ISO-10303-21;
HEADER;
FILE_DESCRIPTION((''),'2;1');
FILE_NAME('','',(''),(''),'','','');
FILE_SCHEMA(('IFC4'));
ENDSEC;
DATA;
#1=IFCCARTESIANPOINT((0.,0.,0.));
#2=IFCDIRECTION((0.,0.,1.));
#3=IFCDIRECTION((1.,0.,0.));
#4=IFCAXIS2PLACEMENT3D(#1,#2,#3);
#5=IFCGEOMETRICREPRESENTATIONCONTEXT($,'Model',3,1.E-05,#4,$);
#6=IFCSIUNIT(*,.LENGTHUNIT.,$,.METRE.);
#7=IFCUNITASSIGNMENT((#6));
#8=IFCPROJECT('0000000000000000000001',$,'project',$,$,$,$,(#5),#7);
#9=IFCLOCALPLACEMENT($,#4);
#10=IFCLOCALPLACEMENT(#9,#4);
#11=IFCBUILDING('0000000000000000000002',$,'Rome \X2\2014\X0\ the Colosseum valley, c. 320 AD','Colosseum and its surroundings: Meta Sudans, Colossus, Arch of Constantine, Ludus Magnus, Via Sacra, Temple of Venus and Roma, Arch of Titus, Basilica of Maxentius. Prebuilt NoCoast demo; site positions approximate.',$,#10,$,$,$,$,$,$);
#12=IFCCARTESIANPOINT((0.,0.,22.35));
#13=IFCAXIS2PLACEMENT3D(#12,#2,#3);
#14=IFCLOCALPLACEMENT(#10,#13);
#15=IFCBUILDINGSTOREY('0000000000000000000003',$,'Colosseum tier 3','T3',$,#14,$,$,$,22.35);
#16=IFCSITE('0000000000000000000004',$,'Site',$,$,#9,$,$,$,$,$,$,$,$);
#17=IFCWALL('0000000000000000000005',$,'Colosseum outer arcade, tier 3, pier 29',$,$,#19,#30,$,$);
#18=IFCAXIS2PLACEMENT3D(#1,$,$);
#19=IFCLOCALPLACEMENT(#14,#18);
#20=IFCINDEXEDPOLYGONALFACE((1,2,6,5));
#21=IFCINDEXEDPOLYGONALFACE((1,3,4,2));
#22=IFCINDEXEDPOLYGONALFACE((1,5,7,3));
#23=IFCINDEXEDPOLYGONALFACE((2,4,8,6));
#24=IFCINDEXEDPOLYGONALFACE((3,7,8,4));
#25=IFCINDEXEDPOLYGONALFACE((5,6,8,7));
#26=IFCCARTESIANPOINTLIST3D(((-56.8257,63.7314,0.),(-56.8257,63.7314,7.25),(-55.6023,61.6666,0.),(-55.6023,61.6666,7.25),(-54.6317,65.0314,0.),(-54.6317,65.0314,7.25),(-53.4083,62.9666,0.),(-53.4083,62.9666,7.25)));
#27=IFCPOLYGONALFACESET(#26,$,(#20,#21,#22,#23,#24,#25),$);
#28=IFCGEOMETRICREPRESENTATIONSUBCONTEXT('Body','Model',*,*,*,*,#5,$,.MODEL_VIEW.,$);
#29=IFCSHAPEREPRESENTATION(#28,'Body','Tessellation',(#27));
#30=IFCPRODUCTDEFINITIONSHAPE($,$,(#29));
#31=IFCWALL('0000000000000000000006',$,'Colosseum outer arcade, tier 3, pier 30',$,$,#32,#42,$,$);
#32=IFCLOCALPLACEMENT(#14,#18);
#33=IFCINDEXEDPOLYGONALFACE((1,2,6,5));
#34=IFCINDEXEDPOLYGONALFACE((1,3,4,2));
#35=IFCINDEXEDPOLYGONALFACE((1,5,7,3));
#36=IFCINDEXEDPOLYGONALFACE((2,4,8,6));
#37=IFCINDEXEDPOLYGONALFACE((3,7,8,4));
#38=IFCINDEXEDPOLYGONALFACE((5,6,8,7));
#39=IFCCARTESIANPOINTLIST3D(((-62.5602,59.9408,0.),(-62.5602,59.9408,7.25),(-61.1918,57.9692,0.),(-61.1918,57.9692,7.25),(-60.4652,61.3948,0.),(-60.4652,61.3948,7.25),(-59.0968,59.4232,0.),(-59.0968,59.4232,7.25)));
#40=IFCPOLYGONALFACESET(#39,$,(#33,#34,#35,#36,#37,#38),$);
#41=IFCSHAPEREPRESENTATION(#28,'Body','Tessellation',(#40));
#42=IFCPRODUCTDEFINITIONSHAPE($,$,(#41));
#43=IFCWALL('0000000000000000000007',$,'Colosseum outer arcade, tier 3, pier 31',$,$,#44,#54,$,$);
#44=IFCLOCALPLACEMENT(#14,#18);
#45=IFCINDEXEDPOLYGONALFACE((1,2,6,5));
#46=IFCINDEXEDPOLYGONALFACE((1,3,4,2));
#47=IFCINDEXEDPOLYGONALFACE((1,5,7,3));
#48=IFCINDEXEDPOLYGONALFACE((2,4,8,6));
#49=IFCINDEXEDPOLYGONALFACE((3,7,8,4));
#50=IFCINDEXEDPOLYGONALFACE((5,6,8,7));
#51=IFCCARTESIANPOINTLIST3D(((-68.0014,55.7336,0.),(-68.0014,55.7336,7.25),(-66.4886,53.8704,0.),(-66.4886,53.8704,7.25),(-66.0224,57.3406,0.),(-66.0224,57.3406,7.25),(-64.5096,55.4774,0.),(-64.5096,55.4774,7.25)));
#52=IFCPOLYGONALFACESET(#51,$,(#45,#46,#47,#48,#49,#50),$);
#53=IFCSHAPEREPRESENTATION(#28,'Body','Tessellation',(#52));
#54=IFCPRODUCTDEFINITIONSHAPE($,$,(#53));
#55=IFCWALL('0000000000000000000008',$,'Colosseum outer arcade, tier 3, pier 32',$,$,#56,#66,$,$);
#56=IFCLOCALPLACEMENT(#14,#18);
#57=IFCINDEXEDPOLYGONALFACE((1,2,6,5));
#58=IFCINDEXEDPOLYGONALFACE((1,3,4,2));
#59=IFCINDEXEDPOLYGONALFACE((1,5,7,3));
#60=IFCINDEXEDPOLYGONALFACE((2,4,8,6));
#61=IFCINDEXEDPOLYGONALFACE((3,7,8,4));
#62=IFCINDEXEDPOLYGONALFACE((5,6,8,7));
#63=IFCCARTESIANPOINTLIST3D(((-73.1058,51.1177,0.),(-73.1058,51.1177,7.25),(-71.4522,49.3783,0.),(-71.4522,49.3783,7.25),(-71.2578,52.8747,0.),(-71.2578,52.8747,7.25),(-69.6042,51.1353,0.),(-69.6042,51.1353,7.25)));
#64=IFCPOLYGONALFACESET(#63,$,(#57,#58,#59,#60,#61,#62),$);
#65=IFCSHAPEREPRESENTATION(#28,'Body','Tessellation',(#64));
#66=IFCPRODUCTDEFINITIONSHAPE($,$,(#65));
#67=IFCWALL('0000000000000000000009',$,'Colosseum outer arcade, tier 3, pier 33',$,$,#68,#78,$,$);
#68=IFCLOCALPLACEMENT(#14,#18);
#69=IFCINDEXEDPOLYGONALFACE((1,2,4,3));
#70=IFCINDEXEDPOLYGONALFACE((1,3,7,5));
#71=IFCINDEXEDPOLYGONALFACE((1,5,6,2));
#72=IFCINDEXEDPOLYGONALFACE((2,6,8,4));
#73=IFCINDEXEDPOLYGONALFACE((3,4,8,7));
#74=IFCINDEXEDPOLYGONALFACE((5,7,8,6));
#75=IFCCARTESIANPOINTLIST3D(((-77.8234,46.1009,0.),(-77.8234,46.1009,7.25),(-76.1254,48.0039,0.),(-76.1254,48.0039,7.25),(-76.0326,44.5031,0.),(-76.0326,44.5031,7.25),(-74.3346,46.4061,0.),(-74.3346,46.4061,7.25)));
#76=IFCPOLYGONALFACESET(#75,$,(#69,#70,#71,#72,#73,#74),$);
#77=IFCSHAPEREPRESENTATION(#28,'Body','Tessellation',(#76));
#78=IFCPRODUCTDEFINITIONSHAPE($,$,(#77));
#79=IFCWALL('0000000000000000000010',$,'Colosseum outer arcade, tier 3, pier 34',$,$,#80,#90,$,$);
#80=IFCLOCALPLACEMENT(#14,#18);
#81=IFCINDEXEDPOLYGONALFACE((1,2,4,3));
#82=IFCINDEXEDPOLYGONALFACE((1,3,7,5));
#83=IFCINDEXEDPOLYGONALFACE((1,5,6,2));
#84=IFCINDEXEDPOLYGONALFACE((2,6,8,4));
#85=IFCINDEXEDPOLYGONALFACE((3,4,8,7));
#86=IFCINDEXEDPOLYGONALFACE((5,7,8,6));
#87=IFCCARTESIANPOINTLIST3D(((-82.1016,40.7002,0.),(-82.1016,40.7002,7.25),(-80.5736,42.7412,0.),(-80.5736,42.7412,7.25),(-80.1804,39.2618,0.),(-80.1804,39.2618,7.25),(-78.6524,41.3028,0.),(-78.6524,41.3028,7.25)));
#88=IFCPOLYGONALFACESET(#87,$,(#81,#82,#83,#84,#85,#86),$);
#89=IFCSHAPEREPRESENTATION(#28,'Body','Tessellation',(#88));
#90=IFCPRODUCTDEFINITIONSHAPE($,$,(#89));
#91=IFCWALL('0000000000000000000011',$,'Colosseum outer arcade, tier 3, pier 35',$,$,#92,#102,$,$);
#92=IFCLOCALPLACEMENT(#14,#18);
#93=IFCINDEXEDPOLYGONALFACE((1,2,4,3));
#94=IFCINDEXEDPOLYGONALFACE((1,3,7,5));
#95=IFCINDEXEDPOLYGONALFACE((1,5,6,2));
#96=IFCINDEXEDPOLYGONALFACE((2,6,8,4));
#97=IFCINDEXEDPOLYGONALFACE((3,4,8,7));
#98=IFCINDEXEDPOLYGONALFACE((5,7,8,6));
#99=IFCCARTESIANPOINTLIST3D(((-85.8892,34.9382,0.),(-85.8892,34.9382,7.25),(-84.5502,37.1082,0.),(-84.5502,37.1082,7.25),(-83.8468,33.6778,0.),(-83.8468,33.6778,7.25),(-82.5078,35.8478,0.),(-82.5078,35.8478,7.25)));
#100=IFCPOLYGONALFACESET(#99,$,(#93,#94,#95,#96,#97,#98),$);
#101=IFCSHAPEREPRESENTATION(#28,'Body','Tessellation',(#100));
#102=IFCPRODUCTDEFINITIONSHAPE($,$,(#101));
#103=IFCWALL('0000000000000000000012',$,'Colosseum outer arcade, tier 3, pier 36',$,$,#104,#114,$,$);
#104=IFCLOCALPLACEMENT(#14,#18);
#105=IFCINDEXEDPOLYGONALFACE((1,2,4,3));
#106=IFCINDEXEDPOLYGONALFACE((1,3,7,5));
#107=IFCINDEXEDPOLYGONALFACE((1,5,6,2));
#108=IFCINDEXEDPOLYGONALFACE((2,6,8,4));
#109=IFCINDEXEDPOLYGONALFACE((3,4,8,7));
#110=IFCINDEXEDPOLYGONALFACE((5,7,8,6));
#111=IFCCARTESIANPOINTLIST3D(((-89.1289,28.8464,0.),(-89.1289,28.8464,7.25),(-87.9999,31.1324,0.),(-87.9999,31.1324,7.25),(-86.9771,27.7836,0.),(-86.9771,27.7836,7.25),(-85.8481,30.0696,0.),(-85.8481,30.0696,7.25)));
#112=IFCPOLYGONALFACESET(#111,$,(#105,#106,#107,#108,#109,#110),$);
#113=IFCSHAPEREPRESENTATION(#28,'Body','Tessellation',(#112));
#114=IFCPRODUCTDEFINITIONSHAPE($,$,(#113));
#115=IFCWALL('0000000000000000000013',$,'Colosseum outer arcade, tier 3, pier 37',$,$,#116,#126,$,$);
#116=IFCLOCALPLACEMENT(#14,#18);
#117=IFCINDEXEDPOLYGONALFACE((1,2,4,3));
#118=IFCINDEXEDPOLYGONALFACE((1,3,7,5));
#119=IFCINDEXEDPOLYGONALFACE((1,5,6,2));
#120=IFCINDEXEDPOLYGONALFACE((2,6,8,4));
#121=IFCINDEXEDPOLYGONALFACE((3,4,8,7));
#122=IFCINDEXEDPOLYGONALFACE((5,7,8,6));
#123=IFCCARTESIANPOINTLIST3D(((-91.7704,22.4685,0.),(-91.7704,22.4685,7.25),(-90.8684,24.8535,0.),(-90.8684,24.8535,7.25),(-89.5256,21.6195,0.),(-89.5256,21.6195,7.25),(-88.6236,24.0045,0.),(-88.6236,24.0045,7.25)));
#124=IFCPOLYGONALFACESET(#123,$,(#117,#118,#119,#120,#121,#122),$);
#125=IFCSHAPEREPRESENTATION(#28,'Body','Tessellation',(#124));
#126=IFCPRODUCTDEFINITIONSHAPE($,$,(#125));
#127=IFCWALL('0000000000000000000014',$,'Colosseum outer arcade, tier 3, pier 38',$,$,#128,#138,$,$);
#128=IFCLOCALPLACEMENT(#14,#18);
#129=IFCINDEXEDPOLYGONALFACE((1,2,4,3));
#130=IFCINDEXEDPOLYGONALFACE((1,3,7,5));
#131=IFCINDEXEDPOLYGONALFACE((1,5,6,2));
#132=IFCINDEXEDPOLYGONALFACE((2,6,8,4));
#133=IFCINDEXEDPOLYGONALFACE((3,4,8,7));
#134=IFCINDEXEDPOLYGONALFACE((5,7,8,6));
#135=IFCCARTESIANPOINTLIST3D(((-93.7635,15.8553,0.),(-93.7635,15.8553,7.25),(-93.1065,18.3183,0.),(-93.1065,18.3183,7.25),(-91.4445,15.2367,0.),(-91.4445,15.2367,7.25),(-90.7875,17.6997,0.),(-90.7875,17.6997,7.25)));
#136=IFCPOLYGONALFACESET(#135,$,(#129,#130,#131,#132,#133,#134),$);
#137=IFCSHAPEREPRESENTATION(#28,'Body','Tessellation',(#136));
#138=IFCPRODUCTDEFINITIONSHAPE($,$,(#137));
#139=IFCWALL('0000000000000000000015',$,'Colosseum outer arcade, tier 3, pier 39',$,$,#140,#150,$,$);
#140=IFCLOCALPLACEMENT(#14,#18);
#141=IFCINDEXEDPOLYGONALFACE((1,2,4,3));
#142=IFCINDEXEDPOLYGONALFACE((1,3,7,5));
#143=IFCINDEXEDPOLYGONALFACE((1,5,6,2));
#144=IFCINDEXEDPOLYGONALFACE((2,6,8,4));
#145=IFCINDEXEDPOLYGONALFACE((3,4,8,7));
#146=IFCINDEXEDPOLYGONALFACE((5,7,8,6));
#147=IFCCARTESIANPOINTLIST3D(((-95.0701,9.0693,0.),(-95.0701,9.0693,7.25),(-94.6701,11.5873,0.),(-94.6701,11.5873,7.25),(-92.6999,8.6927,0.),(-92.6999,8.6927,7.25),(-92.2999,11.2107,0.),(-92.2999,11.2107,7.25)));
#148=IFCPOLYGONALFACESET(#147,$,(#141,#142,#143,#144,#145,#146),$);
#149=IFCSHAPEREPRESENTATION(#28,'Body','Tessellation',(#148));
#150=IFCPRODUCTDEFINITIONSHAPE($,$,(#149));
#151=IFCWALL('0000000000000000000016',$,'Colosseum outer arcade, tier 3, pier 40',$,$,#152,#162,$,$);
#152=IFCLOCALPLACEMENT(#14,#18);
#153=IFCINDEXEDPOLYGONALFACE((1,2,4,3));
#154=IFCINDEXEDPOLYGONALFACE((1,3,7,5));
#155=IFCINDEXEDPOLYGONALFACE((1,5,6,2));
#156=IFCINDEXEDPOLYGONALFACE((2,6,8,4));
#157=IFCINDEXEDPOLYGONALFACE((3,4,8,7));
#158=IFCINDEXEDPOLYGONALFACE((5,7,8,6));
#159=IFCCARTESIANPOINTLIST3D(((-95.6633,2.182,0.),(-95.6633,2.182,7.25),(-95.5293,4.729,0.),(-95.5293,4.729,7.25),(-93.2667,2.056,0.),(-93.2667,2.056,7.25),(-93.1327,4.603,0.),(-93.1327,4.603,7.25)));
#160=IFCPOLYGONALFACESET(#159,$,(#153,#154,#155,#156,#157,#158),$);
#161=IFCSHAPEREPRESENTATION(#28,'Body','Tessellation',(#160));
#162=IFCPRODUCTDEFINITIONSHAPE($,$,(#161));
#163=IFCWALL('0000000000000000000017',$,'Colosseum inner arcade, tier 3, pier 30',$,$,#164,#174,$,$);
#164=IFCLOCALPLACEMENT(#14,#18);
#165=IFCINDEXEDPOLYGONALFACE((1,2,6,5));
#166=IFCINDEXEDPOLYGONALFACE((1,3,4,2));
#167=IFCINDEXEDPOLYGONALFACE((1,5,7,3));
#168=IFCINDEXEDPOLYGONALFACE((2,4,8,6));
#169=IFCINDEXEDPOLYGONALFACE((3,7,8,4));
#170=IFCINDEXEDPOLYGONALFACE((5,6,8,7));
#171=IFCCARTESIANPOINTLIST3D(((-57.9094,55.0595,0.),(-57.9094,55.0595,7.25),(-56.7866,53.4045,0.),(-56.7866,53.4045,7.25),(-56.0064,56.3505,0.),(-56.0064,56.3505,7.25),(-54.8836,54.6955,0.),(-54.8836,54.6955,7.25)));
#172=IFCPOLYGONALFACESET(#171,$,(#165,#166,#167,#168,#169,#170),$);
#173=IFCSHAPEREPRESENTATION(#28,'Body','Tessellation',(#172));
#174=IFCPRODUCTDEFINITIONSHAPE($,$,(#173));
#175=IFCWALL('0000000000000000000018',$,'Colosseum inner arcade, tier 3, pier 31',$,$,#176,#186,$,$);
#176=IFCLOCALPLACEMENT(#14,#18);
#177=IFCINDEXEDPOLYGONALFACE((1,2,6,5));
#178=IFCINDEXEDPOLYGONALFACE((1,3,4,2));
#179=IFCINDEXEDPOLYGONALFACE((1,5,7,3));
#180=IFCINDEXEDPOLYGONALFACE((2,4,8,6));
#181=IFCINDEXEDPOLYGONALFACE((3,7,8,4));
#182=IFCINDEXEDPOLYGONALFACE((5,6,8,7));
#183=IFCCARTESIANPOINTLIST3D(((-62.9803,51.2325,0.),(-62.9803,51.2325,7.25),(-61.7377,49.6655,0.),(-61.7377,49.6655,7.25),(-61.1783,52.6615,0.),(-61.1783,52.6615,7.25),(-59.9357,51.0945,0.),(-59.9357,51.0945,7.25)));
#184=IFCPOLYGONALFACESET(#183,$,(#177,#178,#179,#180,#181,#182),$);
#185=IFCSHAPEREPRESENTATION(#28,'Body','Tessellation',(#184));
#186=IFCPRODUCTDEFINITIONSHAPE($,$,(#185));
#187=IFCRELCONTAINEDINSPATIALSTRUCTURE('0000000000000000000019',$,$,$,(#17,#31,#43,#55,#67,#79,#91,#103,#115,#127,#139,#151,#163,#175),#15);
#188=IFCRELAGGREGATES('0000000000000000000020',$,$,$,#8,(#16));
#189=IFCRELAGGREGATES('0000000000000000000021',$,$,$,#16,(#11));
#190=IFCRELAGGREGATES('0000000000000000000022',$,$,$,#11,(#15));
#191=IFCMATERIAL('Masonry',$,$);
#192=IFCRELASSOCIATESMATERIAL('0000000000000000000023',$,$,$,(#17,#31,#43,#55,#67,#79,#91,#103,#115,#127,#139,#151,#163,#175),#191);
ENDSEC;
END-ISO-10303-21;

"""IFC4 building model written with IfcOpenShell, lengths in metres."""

from ifc_helpers import new_model, si_unit, frame, origin_with_axes, place, context, subcontext, project, spatial, indexed_curve, outline, extrude, material, element, save


model = new_model("IFC4")

# Units and contexts
model_context = context("Model", 3, precision=1e-05, world=origin_with_axes())
body_context = subcontext(model_context, "Body", "Model", "MODEL_VIEW")
ifc_project = project(units=[si_unit("LENGTHUNIT", "METRE")], contexts=[model_context])

# Site, building, storey
site_placement = place(None, origin_with_axes())
site = spatial("IfcSite", under=ifc_project, at=site_placement, Name="Site")
building_placement = place(site_placement, origin_with_axes())
building = spatial("IfcBuilding", under=site, at=building_placement, Name="Rome — the Colosseum valley, c. 320 AD", Description="Colosseum and its surroundings: Meta Sudans, Colossus, Arch of Constantine, Ludus Magnus, Via Sacra, Temple of Venus and Roma, Arch of Titus, Basilica of Maxentius. Prebuilt NoCoast demo; site positions approximate.")
storey_placement = place(building_placement, frame((0.0, 0.0, 22.35), z_axis=(0.0, 0.0, 1.0), x_axis=(1.0, 0.0, 0.0)))
storey = spatial("IfcBuildingStorey", under=building, at=storey_placement, Name="Colosseum tier 3", Description="T3", Elevation=22.35)

# Walls
ifc_material = material(Name="Masonry")
wall_1_placement = place(storey_placement, frame((-54.02, 63.999, 0.0), z_axis=(0.0, 0.0, 1.0), x_axis=(-0.860317, -0.509759, 0.0)))
element("IfcWall", 1, at=wall_1_placement, inside=storey, material=ifc_material, Name="Colosseum outer arcade, tier 3, pier 29", context=body_context, shape_type="SweptSolid", body=[
    extrude(outline(indexed_curve([(0.0, 0.0), (0.0, 2.4), (2.5502, 2.4), (2.5502, 0.0), (0.0, 0.0)], self_intersect=False)), frame((0.0, -1.2, 0.0), z_axis=(0.0, 0.0, 1.0), x_axis=(1.0, 0.0, 0.0)), (0.0, 0.0, 1.0), 7.25),
])
wall_2_placement = place(storey_placement, frame((-59.781, 60.409, 0.0), z_axis=(0.0, 0.0, 1.0), x_axis=(-0.821528, -0.570168, 0.0)))
element("IfcWall", 2, at=wall_2_placement, inside=storey, material=ifc_material, Name="Colosseum outer arcade, tier 3, pier 30", context=body_context, shape_type="SweptSolid", body=[
    extrude(outline(indexed_curve([(0.0, 0.0), (0.0, 2.4), (2.5501, 2.4), (2.5501, 0.0), (0.0, 0.0)], self_intersect=False)), frame((0.0, -1.2, 0.0), z_axis=(0.0, 0.0, 1.0), x_axis=(1.0, 0.0, 0.0)), (0.0, 0.0, 1.0), 7.25),
])
wall_3_placement = place(storey_placement, frame((-65.266, 56.409, 0.0), z_axis=(0.0, 0.0, 1.0), x_axis=(-0.776294, -0.630371, 0.0)))
element("IfcWall", 3, at=wall_3_placement, inside=storey, material=ifc_material, Name="Colosseum outer arcade, tier 3, pier 31", context=body_context, shape_type="SweptSolid", body=[
    extrude(outline(indexed_curve([(0.0, 0.0), (0.0, 2.4), (2.5493, 2.4), (2.5493, 0.0), (0.0, 0.0)], self_intersect=False)), frame((0.0, -1.2, 0.0), z_axis=(0.0, 0.0, 1.0), x_axis=(1.0, 0.0, 0.0)), (0.0, 0.0, 1.0), 7.25),
])
wall_4_placement = place(storey_placement, frame((-70.431, 52.005, 0.0), z_axis=(0.0, 0.0, 1.0), x_axis=(-0.724725, -0.689038, 0.0)))
element("IfcWall", 4, at=wall_4_placement, inside=storey, material=ifc_material, Name="Colosseum outer arcade, tier 3, pier 32", context=body_context, shape_type="SweptSolid", body=[
    extrude(outline(indexed_curve([(0.0, 0.0), (0.0, 2.4), (2.5499, 2.4), (2.5499, 0.0), (0.0, 0.0)], self_intersect=False)), frame((0.0, -1.2, 0.0), z_axis=(0.0, 0.0, 1.0), x_axis=(1.0, 0.0, 0.0)), (0.0, 0.0, 1.0), 7.25),
])
wall_5_placement = place(storey_placement, frame((-75.23, 47.205, 0.0), z_axis=(0.0, 0.0, 1.0), x_axis=(-0.665774, -0.746153, 0.0)))
element("IfcWall", 5, at=wall_5_placement, inside=storey, material=ifc_material, Name="Colosseum outer arcade, tier 3, pier 33", context=body_context, shape_type="SweptSolid", body=[
    extrude(outline(indexed_curve([(0.0, 0.0), (0.0, 2.4), (2.5504, 2.4), (2.5504, 0.0), (0.0, 0.0)], self_intersect=False)), frame((0.0, -1.2, 0.0), z_axis=(0.0, 0.0, 1.0), x_axis=(1.0, 0.0, 0.0)), (0.0, 0.0, 1.0), 7.25),
])
wall_6_placement = place(storey_placement, frame((-79.613, 42.022, 0.0), z_axis=(0.0, 0.0, 1.0), x_axis=(-0.599309, -0.800517, 0.0)))
element("IfcWall", 6, at=wall_6_placement, inside=storey, material=ifc_material, Name="Colosseum outer arcade, tier 3, pier 34", context=body_context, shape_type="SweptSolid", body=[
    extrude(outline(indexed_curve([(0.0, 0.0), (0.0, 2.4), (2.5496, 2.4), (2.5496, 0.0), (0.0, 0.0)], self_intersect=False)), frame((0.0, -1.2, 0.0), z_axis=(0.0, 0.0, 1.0), x_axis=(1.0, 0.0, 0.0)), (0.0, 0.0, 1.0), 7.25),
])
wall_7_placement = place(storey_placement, frame((-83.529, 36.478, 0.0), z_axis=(0.0, 0.0, 1.0), x_axis=(-0.525125, -0.851025, 0.0)))
element("IfcWall", 7, at=wall_7_placement, inside=storey, material=ifc_material, Name="Colosseum outer arcade, tier 3, pier 35", context=body_context, shape_type="SweptSolid", body=[
    extrude(outline(indexed_curve([(0.0, 0.0), (0.0, 2.4), (2.5499, 2.4), (2.5499, 0.0), (0.0, 0.0)], self_intersect=False)), frame((0.0, -1.2, 0.0), z_axis=(0.0, 0.0, 1.0), x_axis=(1.0, 0.0, 0.0)), (0.0, 0.0, 1.0), 7.25),
])
wall_8_placement = place(storey_placement, frame((-86.924, 30.601, 0.0), z_axis=(0.0, 0.0, 1.0), x_axis=(-0.442815, -0.896613, 0.0)))
element("IfcWall", 8, at=wall_8_placement, inside=storey, material=ifc_material, Name="Colosseum outer arcade, tier 3, pier 36", context=body_context, shape_type="SweptSolid", body=[
    extrude(outline(indexed_curve([(0.0, 0.0), (0.0, 2.4), (2.5496, 2.4), (2.5496, 0.0), (0.0, 0.0)], self_intersect=False)), frame((0.0, -1.2, 0.0), z_axis=(0.0, 0.0, 1.0), x_axis=(1.0, 0.0, 0.0)), (0.0, 0.0, 1.0), 7.25),
])
wall_9_placement = place(storey_placement, frame((-89.746, 24.429, 0.0), z_axis=(0.0, 0.0, 1.0), x_axis=(-0.353744, -0.935342, 0.0)))
element("IfcWall", 9, at=wall_9_placement, inside=storey, material=ifc_material, Name="Colosseum outer arcade, tier 3, pier 37", context=body_context, shape_type="SweptSolid", body=[
    extrude(outline(indexed_curve([(0.0, 0.0), (0.0, 2.4), (2.5499, 2.4), (2.5499, 0.0), (0.0, 0.0)], self_intersect=False)), frame((0.0, -1.2, 0.0), z_axis=(0.0, 0.0, 1.0), x_axis=(1.0, 0.0, 0.0)), (0.0, 0.0, 1.0), 7.25),
])
wall_10_placement = place(storey_placement, frame((-91.947, 18.009, 0.0), z_axis=(0.0, 0.0, 1.0), x_axis=(-0.257736, -0.966215, 0.0)))
element("IfcWall", 10, at=wall_10_placement, inside=storey, material=ifc_material, Name="Colosseum outer arcade, tier 3, pier 38", context=body_context, shape_type="SweptSolid", body=[
    extrude(outline(indexed_curve([(0.0, 0.0), (0.0, 2.4), (2.5491, 2.4), (2.5491, 0.0), (0.0, 0.0)], self_intersect=False)), frame((0.0, -1.2, 0.0), z_axis=(0.0, 0.0, 1.0), x_axis=(1.0, 0.0, 0.0)), (0.0, 0.0, 1.0), 7.25),
])
wall_11_placement = place(storey_placement, frame((-93.485, 11.399, 0.0), z_axis=(0.0, 0.0, 1.0), x_axis=(-0.156889, -0.987616, 0.0)))
element("IfcWall", 11, at=wall_11_placement, inside=storey, material=ifc_material, Name="Colosseum outer arcade, tier 3, pier 39", context=body_context, shape_type="SweptSolid", body=[
    extrude(outline(indexed_curve([(0.0, 0.0), (0.0, 2.4), (2.5496, 2.4), (2.5496, 0.0), (0.0, 0.0)], self_intersect=False)), frame((0.0, -1.2, 0.0), z_axis=(0.0, 0.0, 1.0), x_axis=(1.0, 0.0, 0.0)), (0.0, 0.0, 1.0), 7.25),
])
wall_12_placement = place(storey_placement, frame((-94.331, 4.666, 0.0), z_axis=(0.0, 0.0, 1.0), x_axis=(-0.052538, -0.998619, 0.0)))
element("IfcWall", 12, at=wall_12_placement, inside=storey, material=ifc_material, Name="Colosseum outer arcade, tier 3, pier 40", context=body_context, shape_type="SweptSolid", body=[
    extrude(outline(indexed_curve([(0.0, 0.0), (0.0, 2.4), (2.5505, 2.4), (2.5505, 0.0), (0.0, 0.0)], self_intersect=False)), frame((0.0, -1.2, 0.0), z_axis=(0.0, 0.0, 1.0), x_axis=(1.0, 0.0, 0.0)), (0.0, 0.0, 1.0), 7.25),
])
wall_13_placement = place(storey_placement, frame((-55.445, 55.523, 0.0), z_axis=(0.0, 0.0, 1.0), x_axis=(-0.827541, -0.561406, 0.0)))
element("IfcWall", 13, at=wall_13_placement, inside=storey, material=ifc_material, Name="Colosseum inner arcade, tier 3, pier 30", context=body_context, shape_type="SweptSolid", body=[
    extrude(outline(indexed_curve([(0.0, 0.0), (0.0, 2.0), (2.2996, 2.0), (2.2996, 0.0), (0.0, 0.0)], self_intersect=False)), frame((0.0, -1.0, 0.0), z_axis=(0.0, 0.0, 1.0), x_axis=(1.0, 0.0, 0.0)), (0.0, 0.0, 1.0), 7.25),
])
wall_14_placement = place(storey_placement, frame((-60.557, 51.878, 0.0), z_axis=(0.0, 0.0, 1.0), x_axis=(-0.783534, -0.621349, 0.0)))
element("IfcWall", 14, at=wall_14_placement, inside=storey, material=ifc_material, Name="Colosseum inner arcade, tier 3, pier 31", context=body_context, shape_type="SweptSolid", body=[
    extrude(outline(indexed_curve([(0.0, 0.0), (0.0, 2.0), (2.2998, 2.0), (2.2998, 0.0), (0.0, 0.0)], self_intersect=False)), frame((0.0, -1.0, 0.0), z_axis=(0.0, 0.0, 1.0), x_axis=(1.0, 0.0, 0.0)), (0.0, 0.0, 1.0), 7.25),
])

save(model, "model.ifc")
